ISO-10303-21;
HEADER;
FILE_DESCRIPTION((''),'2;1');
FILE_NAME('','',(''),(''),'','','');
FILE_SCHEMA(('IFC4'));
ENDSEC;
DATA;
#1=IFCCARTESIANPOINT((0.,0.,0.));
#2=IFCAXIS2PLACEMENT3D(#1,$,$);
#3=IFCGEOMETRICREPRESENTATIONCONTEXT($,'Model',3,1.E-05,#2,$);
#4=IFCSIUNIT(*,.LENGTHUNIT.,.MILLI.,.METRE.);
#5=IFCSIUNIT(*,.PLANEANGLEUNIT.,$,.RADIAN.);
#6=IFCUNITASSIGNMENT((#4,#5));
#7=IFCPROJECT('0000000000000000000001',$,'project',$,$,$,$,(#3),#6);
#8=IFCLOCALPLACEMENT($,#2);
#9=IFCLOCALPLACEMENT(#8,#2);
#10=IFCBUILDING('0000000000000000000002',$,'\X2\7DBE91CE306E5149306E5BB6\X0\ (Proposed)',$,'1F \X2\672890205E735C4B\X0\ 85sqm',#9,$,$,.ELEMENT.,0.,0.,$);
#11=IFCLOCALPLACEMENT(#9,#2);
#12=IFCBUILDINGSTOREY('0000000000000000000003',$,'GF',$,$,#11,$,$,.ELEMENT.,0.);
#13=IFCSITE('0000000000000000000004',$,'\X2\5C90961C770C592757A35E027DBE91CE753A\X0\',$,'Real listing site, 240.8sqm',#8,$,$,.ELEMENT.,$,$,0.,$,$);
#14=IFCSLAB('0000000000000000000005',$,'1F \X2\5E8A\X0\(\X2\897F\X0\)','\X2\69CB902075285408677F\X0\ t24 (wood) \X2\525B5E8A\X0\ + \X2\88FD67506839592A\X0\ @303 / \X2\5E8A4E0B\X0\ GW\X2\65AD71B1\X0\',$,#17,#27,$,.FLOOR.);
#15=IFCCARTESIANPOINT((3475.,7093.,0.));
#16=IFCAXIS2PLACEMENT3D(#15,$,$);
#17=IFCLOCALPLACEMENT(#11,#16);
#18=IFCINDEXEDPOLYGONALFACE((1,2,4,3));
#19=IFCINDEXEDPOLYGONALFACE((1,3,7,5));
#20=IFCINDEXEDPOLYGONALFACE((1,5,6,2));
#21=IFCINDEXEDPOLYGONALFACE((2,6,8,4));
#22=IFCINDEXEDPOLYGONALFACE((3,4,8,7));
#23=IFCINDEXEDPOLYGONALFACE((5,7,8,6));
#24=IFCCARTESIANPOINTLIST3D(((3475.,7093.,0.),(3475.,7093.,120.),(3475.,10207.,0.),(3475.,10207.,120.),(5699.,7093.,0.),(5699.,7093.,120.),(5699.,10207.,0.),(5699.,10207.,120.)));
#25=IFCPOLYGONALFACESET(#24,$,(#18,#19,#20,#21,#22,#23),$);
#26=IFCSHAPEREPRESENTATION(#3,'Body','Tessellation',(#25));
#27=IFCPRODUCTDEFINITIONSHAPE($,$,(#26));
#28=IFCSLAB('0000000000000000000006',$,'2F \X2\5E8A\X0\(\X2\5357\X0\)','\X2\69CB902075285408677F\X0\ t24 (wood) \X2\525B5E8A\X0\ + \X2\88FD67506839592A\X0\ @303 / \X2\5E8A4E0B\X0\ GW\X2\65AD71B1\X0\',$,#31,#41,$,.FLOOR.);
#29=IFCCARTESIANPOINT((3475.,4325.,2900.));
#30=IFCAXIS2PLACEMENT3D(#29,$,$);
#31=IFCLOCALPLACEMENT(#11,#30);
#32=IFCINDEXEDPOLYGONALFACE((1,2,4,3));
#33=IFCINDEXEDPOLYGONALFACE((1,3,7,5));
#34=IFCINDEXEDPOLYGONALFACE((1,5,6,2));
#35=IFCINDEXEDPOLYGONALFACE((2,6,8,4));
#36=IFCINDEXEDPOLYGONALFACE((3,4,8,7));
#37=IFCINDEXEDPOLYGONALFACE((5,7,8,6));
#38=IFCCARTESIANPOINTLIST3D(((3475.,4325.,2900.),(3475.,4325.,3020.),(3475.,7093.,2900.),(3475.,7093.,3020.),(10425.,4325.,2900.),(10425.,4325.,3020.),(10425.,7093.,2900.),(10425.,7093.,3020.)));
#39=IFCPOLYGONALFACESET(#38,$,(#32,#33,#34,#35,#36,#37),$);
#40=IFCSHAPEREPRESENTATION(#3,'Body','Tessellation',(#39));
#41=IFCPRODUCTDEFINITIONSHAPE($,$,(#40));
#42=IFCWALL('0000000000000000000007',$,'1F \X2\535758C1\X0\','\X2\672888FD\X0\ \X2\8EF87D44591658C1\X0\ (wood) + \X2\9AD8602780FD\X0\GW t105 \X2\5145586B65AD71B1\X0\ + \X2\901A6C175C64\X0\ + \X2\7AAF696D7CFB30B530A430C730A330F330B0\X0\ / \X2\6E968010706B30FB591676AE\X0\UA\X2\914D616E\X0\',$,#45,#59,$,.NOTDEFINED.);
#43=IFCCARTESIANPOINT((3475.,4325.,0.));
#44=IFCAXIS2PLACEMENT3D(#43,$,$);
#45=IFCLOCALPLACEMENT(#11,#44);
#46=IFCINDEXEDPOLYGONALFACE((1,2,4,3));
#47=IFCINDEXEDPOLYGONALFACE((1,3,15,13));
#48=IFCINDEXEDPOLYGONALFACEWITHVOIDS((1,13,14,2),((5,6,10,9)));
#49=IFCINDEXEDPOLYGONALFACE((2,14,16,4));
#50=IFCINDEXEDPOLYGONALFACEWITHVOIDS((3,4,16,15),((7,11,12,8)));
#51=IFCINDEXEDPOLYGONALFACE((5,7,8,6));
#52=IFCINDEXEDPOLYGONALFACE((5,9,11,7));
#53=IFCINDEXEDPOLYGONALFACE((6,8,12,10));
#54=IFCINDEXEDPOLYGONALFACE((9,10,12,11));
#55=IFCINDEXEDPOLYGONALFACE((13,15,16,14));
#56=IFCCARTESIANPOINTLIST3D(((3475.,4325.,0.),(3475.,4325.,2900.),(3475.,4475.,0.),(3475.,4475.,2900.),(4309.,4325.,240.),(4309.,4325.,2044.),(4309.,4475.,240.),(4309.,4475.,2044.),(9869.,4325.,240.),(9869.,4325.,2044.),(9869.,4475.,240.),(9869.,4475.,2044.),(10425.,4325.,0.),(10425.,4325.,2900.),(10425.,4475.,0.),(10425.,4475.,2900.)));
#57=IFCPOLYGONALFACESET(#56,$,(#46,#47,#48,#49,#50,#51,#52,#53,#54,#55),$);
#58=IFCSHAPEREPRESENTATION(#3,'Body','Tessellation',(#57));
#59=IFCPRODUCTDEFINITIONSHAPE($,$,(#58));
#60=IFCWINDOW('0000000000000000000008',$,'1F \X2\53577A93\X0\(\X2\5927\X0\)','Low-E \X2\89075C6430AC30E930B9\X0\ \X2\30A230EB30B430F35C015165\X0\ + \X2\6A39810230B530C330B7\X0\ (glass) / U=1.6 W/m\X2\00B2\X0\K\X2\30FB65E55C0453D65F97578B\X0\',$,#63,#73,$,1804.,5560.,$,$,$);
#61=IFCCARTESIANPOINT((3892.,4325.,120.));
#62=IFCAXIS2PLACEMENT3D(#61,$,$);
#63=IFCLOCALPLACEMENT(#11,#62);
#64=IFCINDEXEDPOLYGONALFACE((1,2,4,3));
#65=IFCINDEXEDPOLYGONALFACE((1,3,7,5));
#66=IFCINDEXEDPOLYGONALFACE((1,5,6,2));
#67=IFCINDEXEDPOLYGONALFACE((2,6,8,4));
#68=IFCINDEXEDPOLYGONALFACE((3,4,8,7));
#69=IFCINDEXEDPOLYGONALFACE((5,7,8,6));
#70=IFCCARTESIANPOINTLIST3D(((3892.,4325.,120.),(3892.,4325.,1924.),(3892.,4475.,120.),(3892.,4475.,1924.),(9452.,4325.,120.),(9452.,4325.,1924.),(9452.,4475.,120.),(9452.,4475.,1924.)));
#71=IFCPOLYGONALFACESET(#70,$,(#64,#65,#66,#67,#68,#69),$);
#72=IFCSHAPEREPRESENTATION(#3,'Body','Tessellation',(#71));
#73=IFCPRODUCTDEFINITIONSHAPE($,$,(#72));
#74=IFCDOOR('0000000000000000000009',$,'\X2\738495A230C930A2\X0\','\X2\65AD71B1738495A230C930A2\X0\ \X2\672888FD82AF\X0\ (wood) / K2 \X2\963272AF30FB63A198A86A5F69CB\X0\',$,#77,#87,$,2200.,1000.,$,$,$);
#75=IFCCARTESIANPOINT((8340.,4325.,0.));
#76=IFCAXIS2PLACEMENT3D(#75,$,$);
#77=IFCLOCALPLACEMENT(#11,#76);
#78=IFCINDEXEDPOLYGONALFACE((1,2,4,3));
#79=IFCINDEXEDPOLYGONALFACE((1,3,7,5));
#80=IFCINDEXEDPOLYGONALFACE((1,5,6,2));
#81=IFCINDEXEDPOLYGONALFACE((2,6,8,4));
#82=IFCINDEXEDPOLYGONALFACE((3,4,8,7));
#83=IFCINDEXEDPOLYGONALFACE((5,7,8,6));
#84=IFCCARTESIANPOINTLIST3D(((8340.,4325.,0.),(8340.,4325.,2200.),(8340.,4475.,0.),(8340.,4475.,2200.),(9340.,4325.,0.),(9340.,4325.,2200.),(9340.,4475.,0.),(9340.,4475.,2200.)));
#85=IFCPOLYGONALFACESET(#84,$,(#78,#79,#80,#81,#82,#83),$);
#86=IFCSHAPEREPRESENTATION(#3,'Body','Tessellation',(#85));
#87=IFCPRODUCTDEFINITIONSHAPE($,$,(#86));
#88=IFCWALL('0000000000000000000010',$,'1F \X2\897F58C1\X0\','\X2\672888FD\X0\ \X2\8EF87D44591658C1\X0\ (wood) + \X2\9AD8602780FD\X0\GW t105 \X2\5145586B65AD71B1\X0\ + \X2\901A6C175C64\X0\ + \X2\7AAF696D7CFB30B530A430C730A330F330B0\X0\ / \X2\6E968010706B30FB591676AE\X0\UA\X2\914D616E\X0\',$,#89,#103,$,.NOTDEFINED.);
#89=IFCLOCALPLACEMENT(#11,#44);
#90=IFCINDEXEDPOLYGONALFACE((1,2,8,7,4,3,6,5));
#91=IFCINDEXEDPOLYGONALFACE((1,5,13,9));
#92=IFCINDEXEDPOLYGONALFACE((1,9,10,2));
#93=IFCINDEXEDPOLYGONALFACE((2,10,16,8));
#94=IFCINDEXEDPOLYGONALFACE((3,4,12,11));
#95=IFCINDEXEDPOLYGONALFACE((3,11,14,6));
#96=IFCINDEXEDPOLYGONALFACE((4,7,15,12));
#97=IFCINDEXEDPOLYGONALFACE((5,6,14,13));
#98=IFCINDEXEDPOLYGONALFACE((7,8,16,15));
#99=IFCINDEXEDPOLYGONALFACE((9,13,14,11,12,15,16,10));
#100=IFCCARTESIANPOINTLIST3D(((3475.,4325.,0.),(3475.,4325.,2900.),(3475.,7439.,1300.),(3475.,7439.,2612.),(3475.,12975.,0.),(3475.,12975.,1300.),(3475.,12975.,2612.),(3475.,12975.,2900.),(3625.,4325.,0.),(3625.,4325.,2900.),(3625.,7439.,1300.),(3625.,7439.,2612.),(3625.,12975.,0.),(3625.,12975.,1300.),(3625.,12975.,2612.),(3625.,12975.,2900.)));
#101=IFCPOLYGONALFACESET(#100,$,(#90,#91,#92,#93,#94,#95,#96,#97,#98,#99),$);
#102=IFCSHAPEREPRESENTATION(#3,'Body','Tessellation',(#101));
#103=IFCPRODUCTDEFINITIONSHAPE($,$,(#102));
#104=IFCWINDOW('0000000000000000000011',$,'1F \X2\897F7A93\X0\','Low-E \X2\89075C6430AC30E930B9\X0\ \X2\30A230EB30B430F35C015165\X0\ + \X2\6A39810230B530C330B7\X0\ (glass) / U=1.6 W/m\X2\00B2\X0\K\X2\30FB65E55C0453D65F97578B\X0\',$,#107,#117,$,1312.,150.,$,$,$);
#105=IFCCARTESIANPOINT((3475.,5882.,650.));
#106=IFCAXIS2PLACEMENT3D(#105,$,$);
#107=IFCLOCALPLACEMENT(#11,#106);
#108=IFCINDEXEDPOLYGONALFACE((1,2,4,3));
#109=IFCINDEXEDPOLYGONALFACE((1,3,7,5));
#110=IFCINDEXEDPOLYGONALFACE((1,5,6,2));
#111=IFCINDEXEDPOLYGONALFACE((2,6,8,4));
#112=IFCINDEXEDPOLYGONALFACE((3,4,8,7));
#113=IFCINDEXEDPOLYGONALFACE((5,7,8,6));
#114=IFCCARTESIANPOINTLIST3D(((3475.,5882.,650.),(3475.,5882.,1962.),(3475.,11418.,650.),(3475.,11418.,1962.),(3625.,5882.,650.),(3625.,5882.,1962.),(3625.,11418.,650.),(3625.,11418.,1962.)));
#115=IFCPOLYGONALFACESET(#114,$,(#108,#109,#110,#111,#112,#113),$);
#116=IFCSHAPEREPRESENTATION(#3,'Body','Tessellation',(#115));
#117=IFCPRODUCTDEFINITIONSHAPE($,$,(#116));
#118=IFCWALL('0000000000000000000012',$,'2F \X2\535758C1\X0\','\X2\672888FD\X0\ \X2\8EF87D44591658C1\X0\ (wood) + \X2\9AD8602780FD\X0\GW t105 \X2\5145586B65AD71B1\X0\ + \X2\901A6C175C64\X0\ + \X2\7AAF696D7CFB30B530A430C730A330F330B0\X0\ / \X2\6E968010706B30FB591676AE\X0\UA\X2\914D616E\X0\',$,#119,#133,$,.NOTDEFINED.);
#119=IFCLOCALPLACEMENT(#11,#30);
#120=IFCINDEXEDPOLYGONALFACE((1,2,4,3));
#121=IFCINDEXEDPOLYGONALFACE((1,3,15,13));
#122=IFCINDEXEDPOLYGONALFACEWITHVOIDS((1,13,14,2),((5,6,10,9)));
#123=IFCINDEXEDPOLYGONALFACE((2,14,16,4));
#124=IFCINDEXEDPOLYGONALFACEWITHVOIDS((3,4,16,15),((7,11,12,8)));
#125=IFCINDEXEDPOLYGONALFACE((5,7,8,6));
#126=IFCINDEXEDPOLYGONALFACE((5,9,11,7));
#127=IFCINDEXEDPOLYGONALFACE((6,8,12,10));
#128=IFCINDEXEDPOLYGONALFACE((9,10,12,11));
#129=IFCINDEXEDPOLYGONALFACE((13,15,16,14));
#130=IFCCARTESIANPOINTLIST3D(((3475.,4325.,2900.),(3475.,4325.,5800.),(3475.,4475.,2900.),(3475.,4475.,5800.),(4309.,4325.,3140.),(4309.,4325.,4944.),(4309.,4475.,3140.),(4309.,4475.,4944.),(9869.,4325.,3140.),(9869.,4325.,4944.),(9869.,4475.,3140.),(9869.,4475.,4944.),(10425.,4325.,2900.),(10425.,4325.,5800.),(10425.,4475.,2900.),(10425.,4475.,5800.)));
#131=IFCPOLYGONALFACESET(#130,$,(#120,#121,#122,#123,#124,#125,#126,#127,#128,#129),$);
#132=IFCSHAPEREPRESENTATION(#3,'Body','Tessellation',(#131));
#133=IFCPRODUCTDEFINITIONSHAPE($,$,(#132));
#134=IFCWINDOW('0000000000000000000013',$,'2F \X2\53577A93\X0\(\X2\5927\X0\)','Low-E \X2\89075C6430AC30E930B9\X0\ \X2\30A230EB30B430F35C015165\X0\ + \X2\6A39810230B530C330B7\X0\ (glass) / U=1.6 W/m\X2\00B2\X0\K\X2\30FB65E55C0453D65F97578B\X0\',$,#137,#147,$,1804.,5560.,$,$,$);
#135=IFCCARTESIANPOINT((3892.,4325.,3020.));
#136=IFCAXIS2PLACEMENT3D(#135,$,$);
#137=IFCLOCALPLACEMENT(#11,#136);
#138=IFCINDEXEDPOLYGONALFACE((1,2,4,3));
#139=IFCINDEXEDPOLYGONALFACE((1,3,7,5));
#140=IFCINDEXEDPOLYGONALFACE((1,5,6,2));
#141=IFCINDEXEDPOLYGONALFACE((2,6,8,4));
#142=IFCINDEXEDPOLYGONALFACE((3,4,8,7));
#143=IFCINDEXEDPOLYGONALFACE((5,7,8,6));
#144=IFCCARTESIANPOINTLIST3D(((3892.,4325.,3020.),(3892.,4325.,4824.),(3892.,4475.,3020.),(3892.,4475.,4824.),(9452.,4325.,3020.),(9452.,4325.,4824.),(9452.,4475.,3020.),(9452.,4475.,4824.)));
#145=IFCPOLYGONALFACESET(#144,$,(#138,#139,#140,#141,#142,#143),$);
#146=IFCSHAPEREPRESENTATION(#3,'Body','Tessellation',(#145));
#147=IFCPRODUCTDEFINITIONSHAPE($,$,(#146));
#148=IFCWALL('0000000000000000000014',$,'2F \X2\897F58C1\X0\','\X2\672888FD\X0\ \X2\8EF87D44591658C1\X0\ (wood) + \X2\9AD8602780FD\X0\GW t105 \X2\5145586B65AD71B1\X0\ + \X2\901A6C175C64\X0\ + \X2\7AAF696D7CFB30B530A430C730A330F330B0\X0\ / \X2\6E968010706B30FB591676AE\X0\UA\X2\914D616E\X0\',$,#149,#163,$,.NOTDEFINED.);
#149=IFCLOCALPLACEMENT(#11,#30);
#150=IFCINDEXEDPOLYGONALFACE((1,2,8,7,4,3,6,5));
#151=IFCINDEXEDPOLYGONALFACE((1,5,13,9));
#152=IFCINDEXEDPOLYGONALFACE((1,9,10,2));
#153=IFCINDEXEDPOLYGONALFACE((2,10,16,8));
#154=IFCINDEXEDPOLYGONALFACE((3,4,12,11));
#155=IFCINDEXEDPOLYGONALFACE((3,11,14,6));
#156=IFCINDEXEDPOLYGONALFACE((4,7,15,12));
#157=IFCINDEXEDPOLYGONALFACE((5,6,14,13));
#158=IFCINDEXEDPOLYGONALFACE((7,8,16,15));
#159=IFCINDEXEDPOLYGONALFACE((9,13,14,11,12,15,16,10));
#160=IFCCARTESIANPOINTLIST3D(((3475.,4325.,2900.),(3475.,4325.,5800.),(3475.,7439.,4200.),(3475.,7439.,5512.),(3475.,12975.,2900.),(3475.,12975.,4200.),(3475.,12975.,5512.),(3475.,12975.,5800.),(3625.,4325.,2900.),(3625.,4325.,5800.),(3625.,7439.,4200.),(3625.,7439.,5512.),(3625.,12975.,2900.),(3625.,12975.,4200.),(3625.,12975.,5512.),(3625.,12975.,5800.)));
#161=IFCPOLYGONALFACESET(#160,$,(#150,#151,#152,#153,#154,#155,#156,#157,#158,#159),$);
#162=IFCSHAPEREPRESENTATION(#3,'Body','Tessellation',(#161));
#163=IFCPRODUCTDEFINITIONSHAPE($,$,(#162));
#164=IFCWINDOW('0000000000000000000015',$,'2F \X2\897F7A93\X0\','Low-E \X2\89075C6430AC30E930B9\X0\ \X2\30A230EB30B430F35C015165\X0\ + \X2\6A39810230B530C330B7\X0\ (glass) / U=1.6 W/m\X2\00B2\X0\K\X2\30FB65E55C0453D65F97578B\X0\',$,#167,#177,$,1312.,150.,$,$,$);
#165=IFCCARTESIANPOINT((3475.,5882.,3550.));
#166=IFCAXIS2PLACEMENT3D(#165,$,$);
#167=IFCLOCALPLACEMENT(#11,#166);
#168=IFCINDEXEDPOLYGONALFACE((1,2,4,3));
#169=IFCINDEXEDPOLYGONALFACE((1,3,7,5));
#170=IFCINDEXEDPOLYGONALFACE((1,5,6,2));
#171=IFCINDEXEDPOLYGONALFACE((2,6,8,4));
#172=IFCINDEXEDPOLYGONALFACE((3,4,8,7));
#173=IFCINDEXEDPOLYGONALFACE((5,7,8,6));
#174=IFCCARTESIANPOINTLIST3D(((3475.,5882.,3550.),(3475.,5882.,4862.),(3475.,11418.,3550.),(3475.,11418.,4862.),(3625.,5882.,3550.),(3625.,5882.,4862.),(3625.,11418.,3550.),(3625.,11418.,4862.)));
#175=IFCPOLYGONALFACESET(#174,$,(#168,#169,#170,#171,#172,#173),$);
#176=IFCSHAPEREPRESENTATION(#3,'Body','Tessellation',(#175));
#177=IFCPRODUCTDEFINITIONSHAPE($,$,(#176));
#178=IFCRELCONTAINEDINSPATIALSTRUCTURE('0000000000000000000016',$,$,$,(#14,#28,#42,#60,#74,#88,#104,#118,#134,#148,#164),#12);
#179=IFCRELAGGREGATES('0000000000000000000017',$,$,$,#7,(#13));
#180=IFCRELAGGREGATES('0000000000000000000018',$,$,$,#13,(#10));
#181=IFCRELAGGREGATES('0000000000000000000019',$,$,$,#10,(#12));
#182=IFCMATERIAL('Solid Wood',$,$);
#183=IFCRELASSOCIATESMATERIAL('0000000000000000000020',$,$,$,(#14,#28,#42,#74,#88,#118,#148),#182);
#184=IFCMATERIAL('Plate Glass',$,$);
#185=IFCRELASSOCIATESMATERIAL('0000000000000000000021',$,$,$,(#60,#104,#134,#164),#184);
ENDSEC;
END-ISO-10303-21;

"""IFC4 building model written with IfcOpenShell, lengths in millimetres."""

from ifc_helpers import new_model, si_unit, frame, frame_2d, origin, place, context, project, spatial, rectangle, extrude, material, element, fill, save


model = new_model("IFC4")

# Units and contexts
model_context = context("Model", 3, precision=1e-05, world=origin())
ifc_project = project(units=[si_unit("LENGTHUNIT", "METRE", prefix="MILLI"), si_unit("PLANEANGLEUNIT", "RADIAN")], contexts=[model_context])

# Site, building, storey
site_placement = place(None, origin())
site = spatial("IfcSite", under=ifc_project, at=site_placement, Name="岐阜県大垣市綾野町", ObjectType="Real listing site, 240.8sqm", CompositionType="ELEMENT", RefElevation=0.0)
building_placement = place(site_placement, origin())
building = spatial("IfcBuilding", under=site, at=building_placement, Name="綾野の光の家 (Proposed)", ObjectType="1F 木造平屋 85sqm", CompositionType="ELEMENT", ElevationOfRefHeight=0.0, ElevationOfTerrain=0.0)
storey_placement = place(building_placement, origin())
storey = spatial("IfcBuildingStorey", under=building, at=storey_placement, Name="GF", CompositionType="ELEMENT", Elevation=0.0)

# Slabs
ifc_material_1 = material(Name="Solid Wood")
slab_1_placement = place(storey_placement, frame((3475.0, 7093.0, 0.0)))
element("IfcSlab", 1, at=slab_1_placement, inside=storey, material=ifc_material_1, Name="1F 床(西)", Description="構造用合板 t24 (wood) 剛床 + 製材根太 @303 / 床下 GW断熱", PredefinedType="FLOOR", context=model_context, shape_type="SweptSolid", body=[
    extrude(rectangle(XDim=2224.0, YDim=3114.0, at=frame_2d((1112.0, 1557.0))), frame((3475.0, 7093.0, 0.0)), (0.0, 0.0, 1.0), 120.0),
])
slab_2_placement = place(storey_placement, frame((3475.0, 4325.0, 2900.0)))
element("IfcSlab", 2, at=slab_2_placement, inside=storey, material=ifc_material_1, Name="2F 床(南)", Description="構造用合板 t24 (wood) 剛床 + 製材根太 @303 / 床下 GW断熱", PredefinedType="FLOOR", context=model_context, shape_type="SweptSolid", body=[
    extrude(rectangle(XDim=6950.0, YDim=2768.0, at=frame_2d((3475.0, 1384.0))), frame((3475.0, 4325.0, 2900.0)), (0.0, 0.0, 1.0), 120.0),
])

# Wall, openings, window, door
wall_1_placement = place(storey_placement, frame((3475.0, 4325.0, 0.0)))
wall_1 = element("IfcWall", 3, at=wall_1_placement, inside=storey, material=ifc_material_1, Name="1F 南壁", Description="木製 軸組外壁 (wood) + 高性能GW t105 充填断熱 + 通気層 + 窯業系サイディング / 準耐火・外皮UA配慮", PredefinedType="NOTDEFINED", context=model_context, shape_type="SweptSolid", body=[
    extrude(rectangle(XDim=6950.0, YDim=150.0, at=frame_2d((3475.0, 75.0))), frame((3475.0, 4325.0, 0.0)), (0.0, 0.0, 1.0), 2900.0),
])
opening_1_placement = place(storey_placement, frame((3892.0, 4325.0, 120.0)))
opening_1 = element("IfcOpeningElement", 4, at=opening_1_placement, cuts=wall_1, PredefinedType="NOTDEFINED", context=model_context, shape_type="SweptSolid", body=[
    extrude(rectangle(XDim=5560.0, YDim=150.0, at=frame_2d((2780.0, 75.0))), frame((3892.0, 4325.0, 120.0)), (0.0, 0.0, 1.0), 1804.0),
])
opening_2_placement = place(storey_placement, frame((8340.0, 4325.0, 0.0)))
opening_2 = element("IfcOpeningElement", 5, at=opening_2_placement, cuts=wall_1, PredefinedType="NOTDEFINED", context=model_context, shape_type="SweptSolid", body=[
    extrude(rectangle(XDim=1000.0, YDim=150.0, at=frame_2d((500.0, 75.0))), frame((8340.0, 4325.0, 0.0)), (0.0, 0.0, 1.0), 2200.0),
])
ifc_material_2 = material(Name="Plate Glass")
window_1_placement = place(storey_placement, frame((3892.0, 4325.0, 120.0)))
window_1 = element("IfcWindow", 6, at=window_1_placement, inside=storey, material=ifc_material_2, Name="1F 南窓(大)", Description="Low-E 複層ガラス アルゴン封入 + 樹脂サッシ (glass) / U=1.6 W/m²K・日射取得型", OverallHeight=1804.0, OverallWidth=5560.0, context=model_context, shape_type="SweptSolid", body=[
    extrude(rectangle(XDim=5560.0, YDim=150.0, at=frame_2d((2780.0, 75.0))), frame((3892.0, 4325.0, 120.0)), (0.0, 0.0, 1.0), 1804.0),
])
fill(opening_1, window_1)
door_placement = place(storey_placement, frame((8340.0, 4325.0, 0.0)))
door = element("IfcDoor", 7, at=door_placement, inside=storey, material=ifc_material_1, Name="玄関ドア", Description="断熱玄関ドア 木製芯 (wood) / K2 防犯・採風機構", OverallHeight=2200.0, OverallWidth=1000.0, context=model_context, shape_type="SweptSolid", body=[
    extrude(rectangle(XDim=1000.0, YDim=150.0, at=frame_2d((500.0, 75.0))), frame((8340.0, 4325.0, 0.0)), (0.0, 0.0, 1.0), 2200.0),
])
fill(opening_2, door)

# Walls, openings, windows
wall_2_placement = place(storey_placement, frame((3475.0, 4325.0, 0.0)))
wall_2 = element("IfcWall", 8, at=wall_2_placement, inside=storey, material=ifc_material_1, Name="1F 西壁", Description="木製 軸組外壁 (wood) + 高性能GW t105 充填断熱 + 通気層 + 窯業系サイディング / 準耐火・外皮UA配慮", PredefinedType="NOTDEFINED", context=model_context, shape_type="SweptSolid", body=[
    extrude(rectangle(XDim=150.0, YDim=8650.0, at=frame_2d((75.0, 4325.0))), frame((3475.0, 4325.0, 0.0)), (0.0, 0.0, 1.0), 2900.0),
])
opening_3_placement = place(storey_placement, frame((3475.0, 5882.0, 650.0)))
opening_3 = element("IfcOpeningElement", 9, at=opening_3_placement, cuts=wall_2, PredefinedType="NOTDEFINED", context=model_context, shape_type="SweptSolid", body=[
    extrude(rectangle(XDim=150.0, YDim=5536.0, at=frame_2d((75.0, 2768.0))), frame((3475.0, 5882.0, 650.0)), (0.0, 0.0, 1.0), 1312.0),
])
window_2_placement = place(storey_placement, frame((3475.0, 5882.0, 650.0)))
window_2 = element("IfcWindow", 10, at=window_2_placement, inside=storey, material=ifc_material_2, Name="1F 西窓", Description="Low-E 複層ガラス アルゴン封入 + 樹脂サッシ (glass) / U=1.6 W/m²K・日射取得型", OverallHeight=1312.0, OverallWidth=150.0, context=model_context, shape_type="SweptSolid", body=[
    extrude(rectangle(XDim=150.0, YDim=5536.0, at=frame_2d((75.0, 2768.0))), frame((3475.0, 5882.0, 650.0)), (0.0, 0.0, 1.0), 1312.0),
])
fill(opening_3, window_2)
wall_3_placement = place(storey_placement, frame((3475.0, 4325.0, 2900.0)))
wall_3 = element("IfcWall", 11, at=wall_3_placement, inside=storey, material=ifc_material_1, Name="2F 南壁", Description="木製 軸組外壁 (wood) + 高性能GW t105 充填断熱 + 通気層 + 窯業系サイディング / 準耐火・外皮UA配慮", PredefinedType="NOTDEFINED", context=model_context, shape_type="SweptSolid", body=[
    extrude(rectangle(XDim=6950.0, YDim=150.0, at=frame_2d((3475.0, 75.0))), frame((3475.0, 4325.0, 2900.0)), (0.0, 0.0, 1.0), 2900.0),
])
opening_4_placement = place(storey_placement, frame((3892.0, 4325.0, 3020.0)))
opening_4 = element("IfcOpeningElement", 12, at=opening_4_placement, cuts=wall_3, PredefinedType="NOTDEFINED", context=model_context, shape_type="SweptSolid", body=[
    extrude(rectangle(XDim=5560.0, YDim=150.0, at=frame_2d((2780.0, 75.0))), frame((3892.0, 4325.0, 3020.0)), (0.0, 0.0, 1.0), 1804.0),
])
window_3_placement = place(storey_placement, frame((3892.0, 4325.0, 3020.0)))
window_3 = element("IfcWindow", 13, at=window_3_placement, inside=storey, material=ifc_material_2, Name="2F 南窓(大)", Description="Low-E 複層ガラス アルゴン封入 + 樹脂サッシ (glass) / U=1.6 W/m²K・日射取得型", OverallHeight=1804.0, OverallWidth=5560.0, context=model_context, shape_type="SweptSolid", body=[
    extrude(rectangle(XDim=5560.0, YDim=150.0, at=frame_2d((2780.0, 75.0))), frame((3892.0, 4325.0, 3020.0)), (0.0, 0.0, 1.0), 1804.0),
])
fill(opening_4, window_3)
wall_4_placement = place(storey_placement, frame((3475.0, 4325.0, 2900.0)))
wall_4 = element("IfcWall", 14, at=wall_4_placement, inside=storey, material=ifc_material_1, Name="2F 西壁", Description="木製 軸組外壁 (wood) + 高性能GW t105 充填断熱 + 通気層 + 窯業系サイディング / 準耐火・外皮UA配慮", PredefinedType="NOTDEFINED", context=model_context, shape_type="SweptSolid", body=[
    extrude(rectangle(XDim=150.0, YDim=8650.0, at=frame_2d((75.0, 4325.0))), frame((3475.0, 4325.0, 2900.0)), (0.0, 0.0, 1.0), 2900.0),
])
opening_5_placement = place(storey_placement, frame((3475.0, 5882.0, 3550.0)))
opening_5 = element("IfcOpeningElement", 15, at=opening_5_placement, cuts=wall_4, PredefinedType="NOTDEFINED", context=model_context, shape_type="SweptSolid", body=[
    extrude(rectangle(XDim=150.0, YDim=5536.0, at=frame_2d((75.0, 2768.0))), frame((3475.0, 5882.0, 3550.0)), (0.0, 0.0, 1.0), 1312.0),
])
window_4_placement = place(storey_placement, frame((3475.0, 5882.0, 3550.0)))
window_4 = element("IfcWindow", 16, at=window_4_placement, inside=storey, material=ifc_material_2, Name="2F 西窓", Description="Low-E 複層ガラス アルゴン封入 + 樹脂サッシ (glass) / U=1.6 W/m²K・日射取得型", OverallHeight=1312.0, OverallWidth=150.0, context=model_context, shape_type="SweptSolid", body=[
    extrude(rectangle(XDim=150.0, YDim=5536.0, at=frame_2d((75.0, 2768.0))), frame((3475.0, 5882.0, 3550.0)), (0.0, 0.0, 1.0), 1312.0),
])
fill(opening_5, window_4)

save(model, "model.ifc")
